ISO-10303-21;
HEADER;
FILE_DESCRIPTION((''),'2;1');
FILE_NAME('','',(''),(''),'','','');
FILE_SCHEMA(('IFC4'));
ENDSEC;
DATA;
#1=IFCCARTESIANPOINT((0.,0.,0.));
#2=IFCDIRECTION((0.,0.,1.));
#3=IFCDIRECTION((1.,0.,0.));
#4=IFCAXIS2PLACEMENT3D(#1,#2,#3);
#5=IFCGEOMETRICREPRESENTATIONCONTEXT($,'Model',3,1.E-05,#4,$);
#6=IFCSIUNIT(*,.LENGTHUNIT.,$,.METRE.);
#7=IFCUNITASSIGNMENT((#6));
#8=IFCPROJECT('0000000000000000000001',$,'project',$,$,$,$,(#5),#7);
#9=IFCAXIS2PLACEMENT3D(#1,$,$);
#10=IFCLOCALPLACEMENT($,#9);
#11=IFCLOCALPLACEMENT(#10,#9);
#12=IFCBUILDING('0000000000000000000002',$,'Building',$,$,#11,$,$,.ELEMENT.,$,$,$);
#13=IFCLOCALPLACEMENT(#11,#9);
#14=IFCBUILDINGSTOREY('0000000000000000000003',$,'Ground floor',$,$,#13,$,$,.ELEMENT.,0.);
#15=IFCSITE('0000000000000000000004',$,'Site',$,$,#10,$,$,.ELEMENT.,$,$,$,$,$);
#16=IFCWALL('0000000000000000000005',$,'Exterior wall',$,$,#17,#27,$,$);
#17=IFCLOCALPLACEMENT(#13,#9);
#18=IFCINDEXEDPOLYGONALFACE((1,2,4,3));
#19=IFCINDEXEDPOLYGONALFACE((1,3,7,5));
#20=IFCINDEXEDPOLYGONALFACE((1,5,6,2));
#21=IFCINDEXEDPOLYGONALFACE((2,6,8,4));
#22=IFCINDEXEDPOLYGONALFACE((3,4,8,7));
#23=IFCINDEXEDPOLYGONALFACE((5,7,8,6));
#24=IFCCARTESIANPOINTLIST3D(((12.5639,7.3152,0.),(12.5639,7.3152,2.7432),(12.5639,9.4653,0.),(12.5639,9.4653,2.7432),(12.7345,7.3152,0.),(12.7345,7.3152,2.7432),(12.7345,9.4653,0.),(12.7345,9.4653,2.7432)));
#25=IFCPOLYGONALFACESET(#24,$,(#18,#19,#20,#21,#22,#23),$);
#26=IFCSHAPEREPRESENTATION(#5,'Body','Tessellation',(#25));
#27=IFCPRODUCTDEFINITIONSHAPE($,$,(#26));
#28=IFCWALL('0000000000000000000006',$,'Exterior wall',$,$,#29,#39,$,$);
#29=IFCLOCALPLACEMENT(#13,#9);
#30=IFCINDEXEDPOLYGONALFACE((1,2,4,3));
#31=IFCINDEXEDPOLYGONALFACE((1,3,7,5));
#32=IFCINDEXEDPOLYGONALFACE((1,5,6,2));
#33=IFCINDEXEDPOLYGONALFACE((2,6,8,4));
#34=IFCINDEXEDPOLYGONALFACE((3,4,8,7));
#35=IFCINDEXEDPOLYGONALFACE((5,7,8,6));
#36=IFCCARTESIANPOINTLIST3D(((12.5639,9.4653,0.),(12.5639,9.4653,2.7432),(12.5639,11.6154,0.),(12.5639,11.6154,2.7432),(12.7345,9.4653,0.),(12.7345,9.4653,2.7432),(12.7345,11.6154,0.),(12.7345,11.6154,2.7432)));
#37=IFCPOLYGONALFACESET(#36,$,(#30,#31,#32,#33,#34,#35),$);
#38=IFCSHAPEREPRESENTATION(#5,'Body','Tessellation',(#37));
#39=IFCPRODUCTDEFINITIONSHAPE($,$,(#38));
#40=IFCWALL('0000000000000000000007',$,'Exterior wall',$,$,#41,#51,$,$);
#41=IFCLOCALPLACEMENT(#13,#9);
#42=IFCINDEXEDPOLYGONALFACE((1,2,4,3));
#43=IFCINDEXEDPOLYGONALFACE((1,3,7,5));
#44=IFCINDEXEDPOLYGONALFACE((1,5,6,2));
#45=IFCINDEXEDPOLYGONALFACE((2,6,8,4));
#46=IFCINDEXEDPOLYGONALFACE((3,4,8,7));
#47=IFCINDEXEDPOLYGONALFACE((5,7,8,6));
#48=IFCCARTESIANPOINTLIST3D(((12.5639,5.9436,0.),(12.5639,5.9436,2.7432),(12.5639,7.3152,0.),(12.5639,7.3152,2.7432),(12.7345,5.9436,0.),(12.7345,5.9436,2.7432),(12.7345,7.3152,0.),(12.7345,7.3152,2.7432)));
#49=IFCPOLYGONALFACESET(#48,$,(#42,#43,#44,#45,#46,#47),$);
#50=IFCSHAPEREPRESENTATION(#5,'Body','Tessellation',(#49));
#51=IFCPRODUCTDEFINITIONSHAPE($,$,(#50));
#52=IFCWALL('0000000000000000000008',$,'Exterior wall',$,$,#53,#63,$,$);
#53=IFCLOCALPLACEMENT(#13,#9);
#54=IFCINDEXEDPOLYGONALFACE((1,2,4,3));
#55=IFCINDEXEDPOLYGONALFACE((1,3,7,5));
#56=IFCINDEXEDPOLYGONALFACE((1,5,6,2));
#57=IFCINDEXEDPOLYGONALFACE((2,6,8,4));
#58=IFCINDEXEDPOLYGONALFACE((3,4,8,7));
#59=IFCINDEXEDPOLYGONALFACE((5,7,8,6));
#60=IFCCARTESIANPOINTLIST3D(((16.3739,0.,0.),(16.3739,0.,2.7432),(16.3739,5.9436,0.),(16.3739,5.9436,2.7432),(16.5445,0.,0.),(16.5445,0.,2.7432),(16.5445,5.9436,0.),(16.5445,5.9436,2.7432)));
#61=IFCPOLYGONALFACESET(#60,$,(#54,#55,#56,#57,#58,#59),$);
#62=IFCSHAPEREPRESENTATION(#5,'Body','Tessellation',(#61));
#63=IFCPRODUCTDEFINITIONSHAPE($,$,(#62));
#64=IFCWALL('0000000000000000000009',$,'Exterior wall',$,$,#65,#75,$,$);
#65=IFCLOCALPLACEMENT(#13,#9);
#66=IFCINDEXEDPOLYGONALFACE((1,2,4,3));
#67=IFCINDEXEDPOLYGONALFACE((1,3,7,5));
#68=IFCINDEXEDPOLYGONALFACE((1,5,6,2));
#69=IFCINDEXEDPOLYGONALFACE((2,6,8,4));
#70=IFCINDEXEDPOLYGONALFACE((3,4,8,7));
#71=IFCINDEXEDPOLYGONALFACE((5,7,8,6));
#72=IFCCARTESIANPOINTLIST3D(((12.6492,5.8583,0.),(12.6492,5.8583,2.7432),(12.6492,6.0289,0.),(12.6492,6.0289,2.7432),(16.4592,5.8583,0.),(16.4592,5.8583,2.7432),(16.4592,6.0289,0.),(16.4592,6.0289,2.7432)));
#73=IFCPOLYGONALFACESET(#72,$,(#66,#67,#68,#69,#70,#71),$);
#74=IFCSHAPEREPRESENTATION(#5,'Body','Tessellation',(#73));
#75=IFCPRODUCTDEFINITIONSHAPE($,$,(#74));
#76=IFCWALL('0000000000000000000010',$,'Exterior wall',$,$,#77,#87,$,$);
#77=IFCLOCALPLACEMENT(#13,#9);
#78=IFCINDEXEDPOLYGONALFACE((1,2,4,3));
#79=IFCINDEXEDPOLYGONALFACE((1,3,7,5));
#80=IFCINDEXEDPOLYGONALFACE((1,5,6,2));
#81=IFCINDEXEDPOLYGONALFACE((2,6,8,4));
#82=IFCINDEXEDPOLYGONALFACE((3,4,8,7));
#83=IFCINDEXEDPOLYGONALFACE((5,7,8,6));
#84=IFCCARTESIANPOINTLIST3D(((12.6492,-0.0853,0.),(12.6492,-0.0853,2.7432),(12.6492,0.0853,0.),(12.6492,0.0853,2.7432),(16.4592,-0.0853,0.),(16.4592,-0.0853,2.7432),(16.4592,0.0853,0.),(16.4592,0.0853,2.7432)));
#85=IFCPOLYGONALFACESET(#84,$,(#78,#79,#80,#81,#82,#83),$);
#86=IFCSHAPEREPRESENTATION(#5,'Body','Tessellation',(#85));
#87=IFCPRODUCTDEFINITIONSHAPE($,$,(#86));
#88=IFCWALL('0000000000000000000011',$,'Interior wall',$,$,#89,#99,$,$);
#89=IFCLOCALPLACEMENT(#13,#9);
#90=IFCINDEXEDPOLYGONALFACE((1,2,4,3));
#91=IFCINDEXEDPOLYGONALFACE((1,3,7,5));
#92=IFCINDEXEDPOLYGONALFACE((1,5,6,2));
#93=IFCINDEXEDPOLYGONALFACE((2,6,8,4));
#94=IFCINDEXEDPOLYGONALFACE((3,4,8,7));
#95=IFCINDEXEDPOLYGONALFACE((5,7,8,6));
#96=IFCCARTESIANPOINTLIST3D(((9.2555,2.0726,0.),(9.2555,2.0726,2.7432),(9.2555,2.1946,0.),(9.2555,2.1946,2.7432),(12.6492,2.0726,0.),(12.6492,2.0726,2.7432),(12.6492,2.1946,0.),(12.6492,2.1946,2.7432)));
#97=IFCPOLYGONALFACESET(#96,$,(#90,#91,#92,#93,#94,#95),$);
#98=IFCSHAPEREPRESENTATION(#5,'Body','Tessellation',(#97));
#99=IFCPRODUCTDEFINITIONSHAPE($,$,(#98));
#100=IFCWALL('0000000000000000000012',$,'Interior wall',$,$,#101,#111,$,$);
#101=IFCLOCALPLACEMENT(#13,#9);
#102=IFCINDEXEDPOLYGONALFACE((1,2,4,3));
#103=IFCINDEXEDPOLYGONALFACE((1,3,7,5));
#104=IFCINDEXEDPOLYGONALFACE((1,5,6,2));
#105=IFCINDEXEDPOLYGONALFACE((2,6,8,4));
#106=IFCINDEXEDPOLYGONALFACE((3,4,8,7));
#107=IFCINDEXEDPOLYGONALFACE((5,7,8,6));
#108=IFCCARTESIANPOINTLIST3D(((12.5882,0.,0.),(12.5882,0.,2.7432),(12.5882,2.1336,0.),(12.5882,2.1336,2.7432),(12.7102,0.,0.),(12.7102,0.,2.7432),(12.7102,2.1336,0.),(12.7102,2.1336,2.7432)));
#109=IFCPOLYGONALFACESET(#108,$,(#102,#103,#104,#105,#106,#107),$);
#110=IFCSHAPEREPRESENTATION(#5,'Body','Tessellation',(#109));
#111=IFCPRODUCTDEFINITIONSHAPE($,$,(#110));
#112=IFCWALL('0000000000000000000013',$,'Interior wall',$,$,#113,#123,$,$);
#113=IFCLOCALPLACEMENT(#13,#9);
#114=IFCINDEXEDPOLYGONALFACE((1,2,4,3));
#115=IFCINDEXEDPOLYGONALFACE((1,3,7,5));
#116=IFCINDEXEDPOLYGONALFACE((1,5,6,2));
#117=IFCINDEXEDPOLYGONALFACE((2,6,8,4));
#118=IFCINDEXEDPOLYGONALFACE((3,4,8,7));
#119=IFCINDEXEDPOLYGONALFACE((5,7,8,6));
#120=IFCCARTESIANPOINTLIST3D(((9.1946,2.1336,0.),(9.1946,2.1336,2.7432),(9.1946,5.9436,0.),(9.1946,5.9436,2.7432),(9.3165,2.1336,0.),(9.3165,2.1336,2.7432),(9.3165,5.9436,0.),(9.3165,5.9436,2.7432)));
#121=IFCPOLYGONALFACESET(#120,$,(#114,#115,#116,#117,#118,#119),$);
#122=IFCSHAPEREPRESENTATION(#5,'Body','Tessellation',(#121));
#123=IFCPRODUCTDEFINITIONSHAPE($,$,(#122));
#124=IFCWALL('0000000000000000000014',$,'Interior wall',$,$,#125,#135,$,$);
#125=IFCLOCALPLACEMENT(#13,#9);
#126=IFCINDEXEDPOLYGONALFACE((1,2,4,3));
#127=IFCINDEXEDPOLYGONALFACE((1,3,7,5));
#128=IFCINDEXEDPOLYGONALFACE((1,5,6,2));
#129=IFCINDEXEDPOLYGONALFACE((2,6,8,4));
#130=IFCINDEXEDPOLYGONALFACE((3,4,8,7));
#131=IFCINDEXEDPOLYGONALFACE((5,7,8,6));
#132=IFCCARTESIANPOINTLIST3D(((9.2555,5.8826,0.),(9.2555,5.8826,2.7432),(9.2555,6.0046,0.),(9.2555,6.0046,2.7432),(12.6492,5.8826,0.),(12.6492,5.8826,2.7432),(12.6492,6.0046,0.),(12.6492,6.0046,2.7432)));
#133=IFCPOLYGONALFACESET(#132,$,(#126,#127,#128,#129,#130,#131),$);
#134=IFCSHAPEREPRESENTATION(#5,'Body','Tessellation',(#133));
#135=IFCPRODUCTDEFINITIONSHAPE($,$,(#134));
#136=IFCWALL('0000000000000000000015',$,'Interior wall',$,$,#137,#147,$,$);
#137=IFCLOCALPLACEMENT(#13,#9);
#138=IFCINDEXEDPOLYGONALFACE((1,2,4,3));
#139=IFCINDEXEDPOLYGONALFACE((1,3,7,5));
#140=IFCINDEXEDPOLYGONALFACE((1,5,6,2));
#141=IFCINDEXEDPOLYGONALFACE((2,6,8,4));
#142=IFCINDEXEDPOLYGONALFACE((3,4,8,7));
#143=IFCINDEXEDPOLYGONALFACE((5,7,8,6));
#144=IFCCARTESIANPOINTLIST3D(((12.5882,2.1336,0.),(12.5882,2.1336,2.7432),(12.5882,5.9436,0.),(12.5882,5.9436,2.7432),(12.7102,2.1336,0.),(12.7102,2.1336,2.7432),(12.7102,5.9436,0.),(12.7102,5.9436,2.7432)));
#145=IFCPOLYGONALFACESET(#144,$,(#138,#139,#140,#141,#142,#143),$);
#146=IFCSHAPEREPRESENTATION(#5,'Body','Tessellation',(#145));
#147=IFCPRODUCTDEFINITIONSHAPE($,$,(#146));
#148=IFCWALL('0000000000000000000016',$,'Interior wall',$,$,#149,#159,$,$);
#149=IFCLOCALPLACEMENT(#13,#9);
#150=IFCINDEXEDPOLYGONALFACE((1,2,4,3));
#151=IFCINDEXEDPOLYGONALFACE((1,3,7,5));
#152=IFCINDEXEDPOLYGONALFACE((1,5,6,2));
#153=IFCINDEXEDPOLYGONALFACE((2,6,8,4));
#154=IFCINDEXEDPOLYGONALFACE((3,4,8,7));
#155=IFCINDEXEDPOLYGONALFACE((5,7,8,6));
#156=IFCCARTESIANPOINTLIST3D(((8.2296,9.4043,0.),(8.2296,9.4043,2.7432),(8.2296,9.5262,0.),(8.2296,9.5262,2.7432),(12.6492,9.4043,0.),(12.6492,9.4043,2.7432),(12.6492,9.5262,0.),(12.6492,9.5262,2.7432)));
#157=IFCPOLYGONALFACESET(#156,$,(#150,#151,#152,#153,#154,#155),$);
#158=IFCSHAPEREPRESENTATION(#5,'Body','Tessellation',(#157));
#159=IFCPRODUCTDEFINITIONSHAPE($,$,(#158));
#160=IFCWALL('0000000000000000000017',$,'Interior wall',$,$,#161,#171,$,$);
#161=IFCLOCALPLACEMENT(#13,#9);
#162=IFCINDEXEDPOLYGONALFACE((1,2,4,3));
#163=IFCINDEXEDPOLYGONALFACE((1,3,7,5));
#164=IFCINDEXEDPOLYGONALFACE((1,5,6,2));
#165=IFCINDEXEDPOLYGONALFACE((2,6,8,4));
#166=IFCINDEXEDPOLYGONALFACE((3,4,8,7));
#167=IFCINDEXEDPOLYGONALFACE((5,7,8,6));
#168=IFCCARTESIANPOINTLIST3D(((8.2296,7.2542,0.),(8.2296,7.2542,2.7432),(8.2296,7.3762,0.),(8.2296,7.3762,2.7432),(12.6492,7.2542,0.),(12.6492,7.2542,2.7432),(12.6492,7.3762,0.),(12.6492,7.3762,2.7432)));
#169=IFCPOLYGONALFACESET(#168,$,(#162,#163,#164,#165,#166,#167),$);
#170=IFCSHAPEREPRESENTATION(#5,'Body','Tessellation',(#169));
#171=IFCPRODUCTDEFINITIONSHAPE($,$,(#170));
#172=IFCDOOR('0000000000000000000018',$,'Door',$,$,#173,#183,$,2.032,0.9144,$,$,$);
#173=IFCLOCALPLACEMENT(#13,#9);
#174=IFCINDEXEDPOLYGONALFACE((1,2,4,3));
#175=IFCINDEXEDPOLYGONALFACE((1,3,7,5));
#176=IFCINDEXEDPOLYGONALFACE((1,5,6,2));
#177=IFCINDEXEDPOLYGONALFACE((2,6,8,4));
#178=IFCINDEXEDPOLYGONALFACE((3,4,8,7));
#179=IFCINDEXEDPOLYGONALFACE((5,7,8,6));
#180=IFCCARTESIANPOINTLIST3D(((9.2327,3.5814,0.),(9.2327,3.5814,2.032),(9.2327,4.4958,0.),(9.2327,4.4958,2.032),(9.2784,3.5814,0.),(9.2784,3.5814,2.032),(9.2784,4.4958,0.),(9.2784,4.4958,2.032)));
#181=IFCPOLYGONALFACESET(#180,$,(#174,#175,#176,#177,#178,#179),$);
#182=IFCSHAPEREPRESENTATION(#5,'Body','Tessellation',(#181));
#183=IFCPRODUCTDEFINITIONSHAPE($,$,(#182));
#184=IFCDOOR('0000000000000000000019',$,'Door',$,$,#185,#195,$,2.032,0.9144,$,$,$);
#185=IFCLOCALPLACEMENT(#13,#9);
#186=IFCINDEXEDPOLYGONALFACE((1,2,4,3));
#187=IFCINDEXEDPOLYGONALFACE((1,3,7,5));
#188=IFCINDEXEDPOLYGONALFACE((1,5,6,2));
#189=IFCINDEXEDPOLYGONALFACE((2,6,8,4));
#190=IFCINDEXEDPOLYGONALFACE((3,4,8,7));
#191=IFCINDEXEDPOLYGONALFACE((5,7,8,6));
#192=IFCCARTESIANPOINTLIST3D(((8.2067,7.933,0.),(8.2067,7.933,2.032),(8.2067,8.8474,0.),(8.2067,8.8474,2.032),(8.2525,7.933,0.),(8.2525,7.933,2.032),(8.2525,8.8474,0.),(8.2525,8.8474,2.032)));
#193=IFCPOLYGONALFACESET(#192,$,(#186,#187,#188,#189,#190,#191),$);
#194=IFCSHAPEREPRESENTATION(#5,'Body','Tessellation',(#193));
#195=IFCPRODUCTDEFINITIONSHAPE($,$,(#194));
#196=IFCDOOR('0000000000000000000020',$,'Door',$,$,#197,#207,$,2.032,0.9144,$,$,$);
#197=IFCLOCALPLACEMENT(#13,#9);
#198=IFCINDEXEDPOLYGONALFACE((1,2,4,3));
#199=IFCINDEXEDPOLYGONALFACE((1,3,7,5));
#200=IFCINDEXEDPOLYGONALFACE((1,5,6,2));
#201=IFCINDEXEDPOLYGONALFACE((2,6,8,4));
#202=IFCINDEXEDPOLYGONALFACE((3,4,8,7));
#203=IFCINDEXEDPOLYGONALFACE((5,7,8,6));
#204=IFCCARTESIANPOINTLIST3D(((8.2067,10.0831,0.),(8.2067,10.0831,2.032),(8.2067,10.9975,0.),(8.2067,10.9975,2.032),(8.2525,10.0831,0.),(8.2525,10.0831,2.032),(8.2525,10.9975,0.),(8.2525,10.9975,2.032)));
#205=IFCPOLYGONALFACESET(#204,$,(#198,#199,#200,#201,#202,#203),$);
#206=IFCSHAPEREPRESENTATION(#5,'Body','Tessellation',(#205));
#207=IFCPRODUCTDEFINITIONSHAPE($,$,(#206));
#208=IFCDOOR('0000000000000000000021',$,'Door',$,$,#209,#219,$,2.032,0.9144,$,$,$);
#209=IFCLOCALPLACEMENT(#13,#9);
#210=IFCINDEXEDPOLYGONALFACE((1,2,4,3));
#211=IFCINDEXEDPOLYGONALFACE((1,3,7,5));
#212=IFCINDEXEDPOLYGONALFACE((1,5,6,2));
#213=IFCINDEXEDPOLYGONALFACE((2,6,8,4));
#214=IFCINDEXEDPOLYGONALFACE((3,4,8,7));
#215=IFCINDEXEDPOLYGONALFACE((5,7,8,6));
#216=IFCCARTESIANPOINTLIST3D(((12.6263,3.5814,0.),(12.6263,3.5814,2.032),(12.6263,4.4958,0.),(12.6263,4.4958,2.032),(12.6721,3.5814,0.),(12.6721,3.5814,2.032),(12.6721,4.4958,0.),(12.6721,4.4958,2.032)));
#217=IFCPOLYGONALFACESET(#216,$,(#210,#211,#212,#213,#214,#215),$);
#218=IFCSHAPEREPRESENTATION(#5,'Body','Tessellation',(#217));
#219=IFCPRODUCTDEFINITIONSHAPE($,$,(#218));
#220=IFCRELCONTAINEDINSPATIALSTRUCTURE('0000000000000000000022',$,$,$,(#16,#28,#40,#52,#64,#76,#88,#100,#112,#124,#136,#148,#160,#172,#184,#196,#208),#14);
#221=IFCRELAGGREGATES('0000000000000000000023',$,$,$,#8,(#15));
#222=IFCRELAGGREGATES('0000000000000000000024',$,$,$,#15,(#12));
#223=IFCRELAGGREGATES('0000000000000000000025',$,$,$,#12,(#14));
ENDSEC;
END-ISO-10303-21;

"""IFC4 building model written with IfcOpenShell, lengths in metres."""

from ifc_helpers import new_model, si_unit, frame, origin, origin_with_axes, origin_2d, place, context, project, spatial, rectangle, extrude, element, save


model = new_model("IFC4")

# Units and contexts
model_context = context("Model", 3, precision=1e-05, world=origin_with_axes())
ifc_project = project(units=[si_unit("LENGTHUNIT", "METRE")], contexts=[model_context])

# Site, building, storey
site_placement = place(None, origin())
site = spatial("IfcSite", under=ifc_project, at=site_placement, Name="Site", CompositionType="ELEMENT")
building_placement = place(site_placement, origin())
building = spatial("IfcBuilding", under=site, at=building_placement, Name="Building", CompositionType="ELEMENT")
storey_placement = place(building_placement, origin())
storey = spatial("IfcBuildingStorey", under=building, at=storey_placement, Name="Ground floor", CompositionType="ELEMENT", Elevation=0.0)

# Walls
for number, where, x_axis, name in (
    (1, (12.6492, 8.3902, 0.0), (0.0, 1.0, 0.0), "Exterior wall"),
    (2, (12.6492, 10.5403, 0.0), (0.0, 1.0, 0.0), "Exterior wall"),
):
    element("IfcWall", number, at=place(storey_placement, frame(where, x_axis=x_axis)), inside=storey, Name=name, context=model_context, shape_type="SweptSolid", body=[
        extrude(rectangle(XDim=2.1501, YDim=0.1707, at=origin_2d()), origin(), (0.0, 0.0, 1.0), 2.7432),
    ])
wall_1_placement = place(storey_placement, frame((12.6492, 6.6294, 0.0), x_axis=(0.0, 1.0, 0.0)))
element("IfcWall", 3, at=wall_1_placement, inside=storey, Name="Exterior wall", context=model_context, shape_type="SweptSolid", body=[
    extrude(rectangle(XDim=1.3716, YDim=0.1707, at=origin_2d()), origin(), (0.0, 0.0, 1.0), 2.7432),
])
wall_2_placement = place(storey_placement, frame((16.4592, 2.9718, 0.0), x_axis=(0.0, 1.0, 0.0)))
element("IfcWall", 4, at=wall_2_placement, inside=storey, Name="Exterior wall", context=model_context, shape_type="SweptSolid", body=[
    extrude(rectangle(XDim=5.9436, YDim=0.1707, at=origin_2d()), origin(), (0.0, 0.0, 1.0), 2.7432),
])
for number, where, x_axis, name in (
    (5, (14.5542, 5.9436, 0.0), (1.0, 0.0, 0.0), "Exterior wall"),
    (6, (14.5542, 0.0, 0.0), (1.0, 0.0, 0.0), "Exterior wall"),
):
    element("IfcWall", number, at=place(storey_placement, frame(where, x_axis=x_axis)), inside=storey, Name=name, context=model_context, shape_type="SweptSolid", body=[
        extrude(rectangle(XDim=3.81, YDim=0.1707, at=origin_2d()), origin(), (0.0, 0.0, 1.0), 2.7432),
    ])
wall_3_placement = place(storey_placement, frame((10.9524, 2.1336, 0.0), x_axis=(1.0, 0.0, 0.0)))
element("IfcWall", 7, at=wall_3_placement, inside=storey, Name="Interior wall", context=model_context, shape_type="SweptSolid", body=[
    extrude(rectangle(XDim=3.3937, YDim=0.1219, at=origin_2d()), origin(), (0.0, 0.0, 1.0), 2.7432),
])
wall_4_placement = place(storey_placement, frame((12.6492, 1.0668, 0.0), x_axis=(0.0, 1.0, 0.0)))
element("IfcWall", 8, at=wall_4_placement, inside=storey, Name="Interior wall", context=model_context, shape_type="SweptSolid", body=[
    extrude(rectangle(XDim=2.1336, YDim=0.1219, at=origin_2d()), origin(), (0.0, 0.0, 1.0), 2.7432),
])
wall_5_placement = place(storey_placement, frame((9.2555, 4.0386, 0.0), x_axis=(0.0, 1.0, 0.0)))
element("IfcWall", 9, at=wall_5_placement, inside=storey, Name="Interior wall", context=model_context, shape_type="SweptSolid", body=[
    extrude(rectangle(XDim=3.81, YDim=0.1219, at=origin_2d()), origin(), (0.0, 0.0, 1.0), 2.7432),
])
wall_6_placement = place(storey_placement, frame((10.9524, 5.9436, 0.0), x_axis=(1.0, 0.0, 0.0)))
element("IfcWall", 10, at=wall_6_placement, inside=storey, Name="Interior wall", context=model_context, shape_type="SweptSolid", body=[
    extrude(rectangle(XDim=3.3937, YDim=0.1219, at=origin_2d()), origin(), (0.0, 0.0, 1.0), 2.7432),
])
wall_7_placement = place(storey_placement, frame((12.6492, 4.0386, 0.0), x_axis=(0.0, 1.0, 0.0)))
element("IfcWall", 11, at=wall_7_placement, inside=storey, Name="Interior wall", context=model_context, shape_type="SweptSolid", body=[
    extrude(rectangle(XDim=3.81, YDim=0.1219, at=origin_2d()), origin(), (0.0, 0.0, 1.0), 2.7432),
])
for number, where, x_axis, name in (
    (12, (10.4394, 9.4653, 0.0), (1.0, 0.0, 0.0), "Interior wall"),
    (13, (10.4394, 7.3152, 0.0), (1.0, 0.0, 0.0), "Interior wall"),
):
    element("IfcWall", number, at=place(storey_placement, frame(where, x_axis=x_axis)), inside=storey, Name=name, context=model_context, shape_type="SweptSolid", body=[
        extrude(rectangle(XDim=4.4196, YDim=0.1219, at=origin_2d()), origin(), (0.0, 0.0, 1.0), 2.7432),
    ])

# Doors
for number, where, x_axis, name in (
    (14, (9.2555, 4.0386, 0.0), (0.0, 1.0, 0.0), "Door"),
    (15, (8.2296, 8.3902, 0.0), (0.0, 1.0, 0.0), "Door"),
    (16, (8.2296, 10.5403, 0.0), (0.0, 1.0, 0.0), "Door"),
    (17, (12.6492, 4.0386, 0.0), (0.0, 1.0, 0.0), "Door"),
):
    element("IfcDoor", number, at=place(storey_placement, frame(where, x_axis=x_axis)), inside=storey, Name=name, OverallHeight=2.032, OverallWidth=0.9144, context=model_context, shape_type="SweptSolid", body=[
        extrude(rectangle(XDim=0.9144, YDim=0.0457, at=origin_2d()), origin(), (0.0, 0.0, 1.0), 2.032),
    ])

save(model, "model.ifc")
